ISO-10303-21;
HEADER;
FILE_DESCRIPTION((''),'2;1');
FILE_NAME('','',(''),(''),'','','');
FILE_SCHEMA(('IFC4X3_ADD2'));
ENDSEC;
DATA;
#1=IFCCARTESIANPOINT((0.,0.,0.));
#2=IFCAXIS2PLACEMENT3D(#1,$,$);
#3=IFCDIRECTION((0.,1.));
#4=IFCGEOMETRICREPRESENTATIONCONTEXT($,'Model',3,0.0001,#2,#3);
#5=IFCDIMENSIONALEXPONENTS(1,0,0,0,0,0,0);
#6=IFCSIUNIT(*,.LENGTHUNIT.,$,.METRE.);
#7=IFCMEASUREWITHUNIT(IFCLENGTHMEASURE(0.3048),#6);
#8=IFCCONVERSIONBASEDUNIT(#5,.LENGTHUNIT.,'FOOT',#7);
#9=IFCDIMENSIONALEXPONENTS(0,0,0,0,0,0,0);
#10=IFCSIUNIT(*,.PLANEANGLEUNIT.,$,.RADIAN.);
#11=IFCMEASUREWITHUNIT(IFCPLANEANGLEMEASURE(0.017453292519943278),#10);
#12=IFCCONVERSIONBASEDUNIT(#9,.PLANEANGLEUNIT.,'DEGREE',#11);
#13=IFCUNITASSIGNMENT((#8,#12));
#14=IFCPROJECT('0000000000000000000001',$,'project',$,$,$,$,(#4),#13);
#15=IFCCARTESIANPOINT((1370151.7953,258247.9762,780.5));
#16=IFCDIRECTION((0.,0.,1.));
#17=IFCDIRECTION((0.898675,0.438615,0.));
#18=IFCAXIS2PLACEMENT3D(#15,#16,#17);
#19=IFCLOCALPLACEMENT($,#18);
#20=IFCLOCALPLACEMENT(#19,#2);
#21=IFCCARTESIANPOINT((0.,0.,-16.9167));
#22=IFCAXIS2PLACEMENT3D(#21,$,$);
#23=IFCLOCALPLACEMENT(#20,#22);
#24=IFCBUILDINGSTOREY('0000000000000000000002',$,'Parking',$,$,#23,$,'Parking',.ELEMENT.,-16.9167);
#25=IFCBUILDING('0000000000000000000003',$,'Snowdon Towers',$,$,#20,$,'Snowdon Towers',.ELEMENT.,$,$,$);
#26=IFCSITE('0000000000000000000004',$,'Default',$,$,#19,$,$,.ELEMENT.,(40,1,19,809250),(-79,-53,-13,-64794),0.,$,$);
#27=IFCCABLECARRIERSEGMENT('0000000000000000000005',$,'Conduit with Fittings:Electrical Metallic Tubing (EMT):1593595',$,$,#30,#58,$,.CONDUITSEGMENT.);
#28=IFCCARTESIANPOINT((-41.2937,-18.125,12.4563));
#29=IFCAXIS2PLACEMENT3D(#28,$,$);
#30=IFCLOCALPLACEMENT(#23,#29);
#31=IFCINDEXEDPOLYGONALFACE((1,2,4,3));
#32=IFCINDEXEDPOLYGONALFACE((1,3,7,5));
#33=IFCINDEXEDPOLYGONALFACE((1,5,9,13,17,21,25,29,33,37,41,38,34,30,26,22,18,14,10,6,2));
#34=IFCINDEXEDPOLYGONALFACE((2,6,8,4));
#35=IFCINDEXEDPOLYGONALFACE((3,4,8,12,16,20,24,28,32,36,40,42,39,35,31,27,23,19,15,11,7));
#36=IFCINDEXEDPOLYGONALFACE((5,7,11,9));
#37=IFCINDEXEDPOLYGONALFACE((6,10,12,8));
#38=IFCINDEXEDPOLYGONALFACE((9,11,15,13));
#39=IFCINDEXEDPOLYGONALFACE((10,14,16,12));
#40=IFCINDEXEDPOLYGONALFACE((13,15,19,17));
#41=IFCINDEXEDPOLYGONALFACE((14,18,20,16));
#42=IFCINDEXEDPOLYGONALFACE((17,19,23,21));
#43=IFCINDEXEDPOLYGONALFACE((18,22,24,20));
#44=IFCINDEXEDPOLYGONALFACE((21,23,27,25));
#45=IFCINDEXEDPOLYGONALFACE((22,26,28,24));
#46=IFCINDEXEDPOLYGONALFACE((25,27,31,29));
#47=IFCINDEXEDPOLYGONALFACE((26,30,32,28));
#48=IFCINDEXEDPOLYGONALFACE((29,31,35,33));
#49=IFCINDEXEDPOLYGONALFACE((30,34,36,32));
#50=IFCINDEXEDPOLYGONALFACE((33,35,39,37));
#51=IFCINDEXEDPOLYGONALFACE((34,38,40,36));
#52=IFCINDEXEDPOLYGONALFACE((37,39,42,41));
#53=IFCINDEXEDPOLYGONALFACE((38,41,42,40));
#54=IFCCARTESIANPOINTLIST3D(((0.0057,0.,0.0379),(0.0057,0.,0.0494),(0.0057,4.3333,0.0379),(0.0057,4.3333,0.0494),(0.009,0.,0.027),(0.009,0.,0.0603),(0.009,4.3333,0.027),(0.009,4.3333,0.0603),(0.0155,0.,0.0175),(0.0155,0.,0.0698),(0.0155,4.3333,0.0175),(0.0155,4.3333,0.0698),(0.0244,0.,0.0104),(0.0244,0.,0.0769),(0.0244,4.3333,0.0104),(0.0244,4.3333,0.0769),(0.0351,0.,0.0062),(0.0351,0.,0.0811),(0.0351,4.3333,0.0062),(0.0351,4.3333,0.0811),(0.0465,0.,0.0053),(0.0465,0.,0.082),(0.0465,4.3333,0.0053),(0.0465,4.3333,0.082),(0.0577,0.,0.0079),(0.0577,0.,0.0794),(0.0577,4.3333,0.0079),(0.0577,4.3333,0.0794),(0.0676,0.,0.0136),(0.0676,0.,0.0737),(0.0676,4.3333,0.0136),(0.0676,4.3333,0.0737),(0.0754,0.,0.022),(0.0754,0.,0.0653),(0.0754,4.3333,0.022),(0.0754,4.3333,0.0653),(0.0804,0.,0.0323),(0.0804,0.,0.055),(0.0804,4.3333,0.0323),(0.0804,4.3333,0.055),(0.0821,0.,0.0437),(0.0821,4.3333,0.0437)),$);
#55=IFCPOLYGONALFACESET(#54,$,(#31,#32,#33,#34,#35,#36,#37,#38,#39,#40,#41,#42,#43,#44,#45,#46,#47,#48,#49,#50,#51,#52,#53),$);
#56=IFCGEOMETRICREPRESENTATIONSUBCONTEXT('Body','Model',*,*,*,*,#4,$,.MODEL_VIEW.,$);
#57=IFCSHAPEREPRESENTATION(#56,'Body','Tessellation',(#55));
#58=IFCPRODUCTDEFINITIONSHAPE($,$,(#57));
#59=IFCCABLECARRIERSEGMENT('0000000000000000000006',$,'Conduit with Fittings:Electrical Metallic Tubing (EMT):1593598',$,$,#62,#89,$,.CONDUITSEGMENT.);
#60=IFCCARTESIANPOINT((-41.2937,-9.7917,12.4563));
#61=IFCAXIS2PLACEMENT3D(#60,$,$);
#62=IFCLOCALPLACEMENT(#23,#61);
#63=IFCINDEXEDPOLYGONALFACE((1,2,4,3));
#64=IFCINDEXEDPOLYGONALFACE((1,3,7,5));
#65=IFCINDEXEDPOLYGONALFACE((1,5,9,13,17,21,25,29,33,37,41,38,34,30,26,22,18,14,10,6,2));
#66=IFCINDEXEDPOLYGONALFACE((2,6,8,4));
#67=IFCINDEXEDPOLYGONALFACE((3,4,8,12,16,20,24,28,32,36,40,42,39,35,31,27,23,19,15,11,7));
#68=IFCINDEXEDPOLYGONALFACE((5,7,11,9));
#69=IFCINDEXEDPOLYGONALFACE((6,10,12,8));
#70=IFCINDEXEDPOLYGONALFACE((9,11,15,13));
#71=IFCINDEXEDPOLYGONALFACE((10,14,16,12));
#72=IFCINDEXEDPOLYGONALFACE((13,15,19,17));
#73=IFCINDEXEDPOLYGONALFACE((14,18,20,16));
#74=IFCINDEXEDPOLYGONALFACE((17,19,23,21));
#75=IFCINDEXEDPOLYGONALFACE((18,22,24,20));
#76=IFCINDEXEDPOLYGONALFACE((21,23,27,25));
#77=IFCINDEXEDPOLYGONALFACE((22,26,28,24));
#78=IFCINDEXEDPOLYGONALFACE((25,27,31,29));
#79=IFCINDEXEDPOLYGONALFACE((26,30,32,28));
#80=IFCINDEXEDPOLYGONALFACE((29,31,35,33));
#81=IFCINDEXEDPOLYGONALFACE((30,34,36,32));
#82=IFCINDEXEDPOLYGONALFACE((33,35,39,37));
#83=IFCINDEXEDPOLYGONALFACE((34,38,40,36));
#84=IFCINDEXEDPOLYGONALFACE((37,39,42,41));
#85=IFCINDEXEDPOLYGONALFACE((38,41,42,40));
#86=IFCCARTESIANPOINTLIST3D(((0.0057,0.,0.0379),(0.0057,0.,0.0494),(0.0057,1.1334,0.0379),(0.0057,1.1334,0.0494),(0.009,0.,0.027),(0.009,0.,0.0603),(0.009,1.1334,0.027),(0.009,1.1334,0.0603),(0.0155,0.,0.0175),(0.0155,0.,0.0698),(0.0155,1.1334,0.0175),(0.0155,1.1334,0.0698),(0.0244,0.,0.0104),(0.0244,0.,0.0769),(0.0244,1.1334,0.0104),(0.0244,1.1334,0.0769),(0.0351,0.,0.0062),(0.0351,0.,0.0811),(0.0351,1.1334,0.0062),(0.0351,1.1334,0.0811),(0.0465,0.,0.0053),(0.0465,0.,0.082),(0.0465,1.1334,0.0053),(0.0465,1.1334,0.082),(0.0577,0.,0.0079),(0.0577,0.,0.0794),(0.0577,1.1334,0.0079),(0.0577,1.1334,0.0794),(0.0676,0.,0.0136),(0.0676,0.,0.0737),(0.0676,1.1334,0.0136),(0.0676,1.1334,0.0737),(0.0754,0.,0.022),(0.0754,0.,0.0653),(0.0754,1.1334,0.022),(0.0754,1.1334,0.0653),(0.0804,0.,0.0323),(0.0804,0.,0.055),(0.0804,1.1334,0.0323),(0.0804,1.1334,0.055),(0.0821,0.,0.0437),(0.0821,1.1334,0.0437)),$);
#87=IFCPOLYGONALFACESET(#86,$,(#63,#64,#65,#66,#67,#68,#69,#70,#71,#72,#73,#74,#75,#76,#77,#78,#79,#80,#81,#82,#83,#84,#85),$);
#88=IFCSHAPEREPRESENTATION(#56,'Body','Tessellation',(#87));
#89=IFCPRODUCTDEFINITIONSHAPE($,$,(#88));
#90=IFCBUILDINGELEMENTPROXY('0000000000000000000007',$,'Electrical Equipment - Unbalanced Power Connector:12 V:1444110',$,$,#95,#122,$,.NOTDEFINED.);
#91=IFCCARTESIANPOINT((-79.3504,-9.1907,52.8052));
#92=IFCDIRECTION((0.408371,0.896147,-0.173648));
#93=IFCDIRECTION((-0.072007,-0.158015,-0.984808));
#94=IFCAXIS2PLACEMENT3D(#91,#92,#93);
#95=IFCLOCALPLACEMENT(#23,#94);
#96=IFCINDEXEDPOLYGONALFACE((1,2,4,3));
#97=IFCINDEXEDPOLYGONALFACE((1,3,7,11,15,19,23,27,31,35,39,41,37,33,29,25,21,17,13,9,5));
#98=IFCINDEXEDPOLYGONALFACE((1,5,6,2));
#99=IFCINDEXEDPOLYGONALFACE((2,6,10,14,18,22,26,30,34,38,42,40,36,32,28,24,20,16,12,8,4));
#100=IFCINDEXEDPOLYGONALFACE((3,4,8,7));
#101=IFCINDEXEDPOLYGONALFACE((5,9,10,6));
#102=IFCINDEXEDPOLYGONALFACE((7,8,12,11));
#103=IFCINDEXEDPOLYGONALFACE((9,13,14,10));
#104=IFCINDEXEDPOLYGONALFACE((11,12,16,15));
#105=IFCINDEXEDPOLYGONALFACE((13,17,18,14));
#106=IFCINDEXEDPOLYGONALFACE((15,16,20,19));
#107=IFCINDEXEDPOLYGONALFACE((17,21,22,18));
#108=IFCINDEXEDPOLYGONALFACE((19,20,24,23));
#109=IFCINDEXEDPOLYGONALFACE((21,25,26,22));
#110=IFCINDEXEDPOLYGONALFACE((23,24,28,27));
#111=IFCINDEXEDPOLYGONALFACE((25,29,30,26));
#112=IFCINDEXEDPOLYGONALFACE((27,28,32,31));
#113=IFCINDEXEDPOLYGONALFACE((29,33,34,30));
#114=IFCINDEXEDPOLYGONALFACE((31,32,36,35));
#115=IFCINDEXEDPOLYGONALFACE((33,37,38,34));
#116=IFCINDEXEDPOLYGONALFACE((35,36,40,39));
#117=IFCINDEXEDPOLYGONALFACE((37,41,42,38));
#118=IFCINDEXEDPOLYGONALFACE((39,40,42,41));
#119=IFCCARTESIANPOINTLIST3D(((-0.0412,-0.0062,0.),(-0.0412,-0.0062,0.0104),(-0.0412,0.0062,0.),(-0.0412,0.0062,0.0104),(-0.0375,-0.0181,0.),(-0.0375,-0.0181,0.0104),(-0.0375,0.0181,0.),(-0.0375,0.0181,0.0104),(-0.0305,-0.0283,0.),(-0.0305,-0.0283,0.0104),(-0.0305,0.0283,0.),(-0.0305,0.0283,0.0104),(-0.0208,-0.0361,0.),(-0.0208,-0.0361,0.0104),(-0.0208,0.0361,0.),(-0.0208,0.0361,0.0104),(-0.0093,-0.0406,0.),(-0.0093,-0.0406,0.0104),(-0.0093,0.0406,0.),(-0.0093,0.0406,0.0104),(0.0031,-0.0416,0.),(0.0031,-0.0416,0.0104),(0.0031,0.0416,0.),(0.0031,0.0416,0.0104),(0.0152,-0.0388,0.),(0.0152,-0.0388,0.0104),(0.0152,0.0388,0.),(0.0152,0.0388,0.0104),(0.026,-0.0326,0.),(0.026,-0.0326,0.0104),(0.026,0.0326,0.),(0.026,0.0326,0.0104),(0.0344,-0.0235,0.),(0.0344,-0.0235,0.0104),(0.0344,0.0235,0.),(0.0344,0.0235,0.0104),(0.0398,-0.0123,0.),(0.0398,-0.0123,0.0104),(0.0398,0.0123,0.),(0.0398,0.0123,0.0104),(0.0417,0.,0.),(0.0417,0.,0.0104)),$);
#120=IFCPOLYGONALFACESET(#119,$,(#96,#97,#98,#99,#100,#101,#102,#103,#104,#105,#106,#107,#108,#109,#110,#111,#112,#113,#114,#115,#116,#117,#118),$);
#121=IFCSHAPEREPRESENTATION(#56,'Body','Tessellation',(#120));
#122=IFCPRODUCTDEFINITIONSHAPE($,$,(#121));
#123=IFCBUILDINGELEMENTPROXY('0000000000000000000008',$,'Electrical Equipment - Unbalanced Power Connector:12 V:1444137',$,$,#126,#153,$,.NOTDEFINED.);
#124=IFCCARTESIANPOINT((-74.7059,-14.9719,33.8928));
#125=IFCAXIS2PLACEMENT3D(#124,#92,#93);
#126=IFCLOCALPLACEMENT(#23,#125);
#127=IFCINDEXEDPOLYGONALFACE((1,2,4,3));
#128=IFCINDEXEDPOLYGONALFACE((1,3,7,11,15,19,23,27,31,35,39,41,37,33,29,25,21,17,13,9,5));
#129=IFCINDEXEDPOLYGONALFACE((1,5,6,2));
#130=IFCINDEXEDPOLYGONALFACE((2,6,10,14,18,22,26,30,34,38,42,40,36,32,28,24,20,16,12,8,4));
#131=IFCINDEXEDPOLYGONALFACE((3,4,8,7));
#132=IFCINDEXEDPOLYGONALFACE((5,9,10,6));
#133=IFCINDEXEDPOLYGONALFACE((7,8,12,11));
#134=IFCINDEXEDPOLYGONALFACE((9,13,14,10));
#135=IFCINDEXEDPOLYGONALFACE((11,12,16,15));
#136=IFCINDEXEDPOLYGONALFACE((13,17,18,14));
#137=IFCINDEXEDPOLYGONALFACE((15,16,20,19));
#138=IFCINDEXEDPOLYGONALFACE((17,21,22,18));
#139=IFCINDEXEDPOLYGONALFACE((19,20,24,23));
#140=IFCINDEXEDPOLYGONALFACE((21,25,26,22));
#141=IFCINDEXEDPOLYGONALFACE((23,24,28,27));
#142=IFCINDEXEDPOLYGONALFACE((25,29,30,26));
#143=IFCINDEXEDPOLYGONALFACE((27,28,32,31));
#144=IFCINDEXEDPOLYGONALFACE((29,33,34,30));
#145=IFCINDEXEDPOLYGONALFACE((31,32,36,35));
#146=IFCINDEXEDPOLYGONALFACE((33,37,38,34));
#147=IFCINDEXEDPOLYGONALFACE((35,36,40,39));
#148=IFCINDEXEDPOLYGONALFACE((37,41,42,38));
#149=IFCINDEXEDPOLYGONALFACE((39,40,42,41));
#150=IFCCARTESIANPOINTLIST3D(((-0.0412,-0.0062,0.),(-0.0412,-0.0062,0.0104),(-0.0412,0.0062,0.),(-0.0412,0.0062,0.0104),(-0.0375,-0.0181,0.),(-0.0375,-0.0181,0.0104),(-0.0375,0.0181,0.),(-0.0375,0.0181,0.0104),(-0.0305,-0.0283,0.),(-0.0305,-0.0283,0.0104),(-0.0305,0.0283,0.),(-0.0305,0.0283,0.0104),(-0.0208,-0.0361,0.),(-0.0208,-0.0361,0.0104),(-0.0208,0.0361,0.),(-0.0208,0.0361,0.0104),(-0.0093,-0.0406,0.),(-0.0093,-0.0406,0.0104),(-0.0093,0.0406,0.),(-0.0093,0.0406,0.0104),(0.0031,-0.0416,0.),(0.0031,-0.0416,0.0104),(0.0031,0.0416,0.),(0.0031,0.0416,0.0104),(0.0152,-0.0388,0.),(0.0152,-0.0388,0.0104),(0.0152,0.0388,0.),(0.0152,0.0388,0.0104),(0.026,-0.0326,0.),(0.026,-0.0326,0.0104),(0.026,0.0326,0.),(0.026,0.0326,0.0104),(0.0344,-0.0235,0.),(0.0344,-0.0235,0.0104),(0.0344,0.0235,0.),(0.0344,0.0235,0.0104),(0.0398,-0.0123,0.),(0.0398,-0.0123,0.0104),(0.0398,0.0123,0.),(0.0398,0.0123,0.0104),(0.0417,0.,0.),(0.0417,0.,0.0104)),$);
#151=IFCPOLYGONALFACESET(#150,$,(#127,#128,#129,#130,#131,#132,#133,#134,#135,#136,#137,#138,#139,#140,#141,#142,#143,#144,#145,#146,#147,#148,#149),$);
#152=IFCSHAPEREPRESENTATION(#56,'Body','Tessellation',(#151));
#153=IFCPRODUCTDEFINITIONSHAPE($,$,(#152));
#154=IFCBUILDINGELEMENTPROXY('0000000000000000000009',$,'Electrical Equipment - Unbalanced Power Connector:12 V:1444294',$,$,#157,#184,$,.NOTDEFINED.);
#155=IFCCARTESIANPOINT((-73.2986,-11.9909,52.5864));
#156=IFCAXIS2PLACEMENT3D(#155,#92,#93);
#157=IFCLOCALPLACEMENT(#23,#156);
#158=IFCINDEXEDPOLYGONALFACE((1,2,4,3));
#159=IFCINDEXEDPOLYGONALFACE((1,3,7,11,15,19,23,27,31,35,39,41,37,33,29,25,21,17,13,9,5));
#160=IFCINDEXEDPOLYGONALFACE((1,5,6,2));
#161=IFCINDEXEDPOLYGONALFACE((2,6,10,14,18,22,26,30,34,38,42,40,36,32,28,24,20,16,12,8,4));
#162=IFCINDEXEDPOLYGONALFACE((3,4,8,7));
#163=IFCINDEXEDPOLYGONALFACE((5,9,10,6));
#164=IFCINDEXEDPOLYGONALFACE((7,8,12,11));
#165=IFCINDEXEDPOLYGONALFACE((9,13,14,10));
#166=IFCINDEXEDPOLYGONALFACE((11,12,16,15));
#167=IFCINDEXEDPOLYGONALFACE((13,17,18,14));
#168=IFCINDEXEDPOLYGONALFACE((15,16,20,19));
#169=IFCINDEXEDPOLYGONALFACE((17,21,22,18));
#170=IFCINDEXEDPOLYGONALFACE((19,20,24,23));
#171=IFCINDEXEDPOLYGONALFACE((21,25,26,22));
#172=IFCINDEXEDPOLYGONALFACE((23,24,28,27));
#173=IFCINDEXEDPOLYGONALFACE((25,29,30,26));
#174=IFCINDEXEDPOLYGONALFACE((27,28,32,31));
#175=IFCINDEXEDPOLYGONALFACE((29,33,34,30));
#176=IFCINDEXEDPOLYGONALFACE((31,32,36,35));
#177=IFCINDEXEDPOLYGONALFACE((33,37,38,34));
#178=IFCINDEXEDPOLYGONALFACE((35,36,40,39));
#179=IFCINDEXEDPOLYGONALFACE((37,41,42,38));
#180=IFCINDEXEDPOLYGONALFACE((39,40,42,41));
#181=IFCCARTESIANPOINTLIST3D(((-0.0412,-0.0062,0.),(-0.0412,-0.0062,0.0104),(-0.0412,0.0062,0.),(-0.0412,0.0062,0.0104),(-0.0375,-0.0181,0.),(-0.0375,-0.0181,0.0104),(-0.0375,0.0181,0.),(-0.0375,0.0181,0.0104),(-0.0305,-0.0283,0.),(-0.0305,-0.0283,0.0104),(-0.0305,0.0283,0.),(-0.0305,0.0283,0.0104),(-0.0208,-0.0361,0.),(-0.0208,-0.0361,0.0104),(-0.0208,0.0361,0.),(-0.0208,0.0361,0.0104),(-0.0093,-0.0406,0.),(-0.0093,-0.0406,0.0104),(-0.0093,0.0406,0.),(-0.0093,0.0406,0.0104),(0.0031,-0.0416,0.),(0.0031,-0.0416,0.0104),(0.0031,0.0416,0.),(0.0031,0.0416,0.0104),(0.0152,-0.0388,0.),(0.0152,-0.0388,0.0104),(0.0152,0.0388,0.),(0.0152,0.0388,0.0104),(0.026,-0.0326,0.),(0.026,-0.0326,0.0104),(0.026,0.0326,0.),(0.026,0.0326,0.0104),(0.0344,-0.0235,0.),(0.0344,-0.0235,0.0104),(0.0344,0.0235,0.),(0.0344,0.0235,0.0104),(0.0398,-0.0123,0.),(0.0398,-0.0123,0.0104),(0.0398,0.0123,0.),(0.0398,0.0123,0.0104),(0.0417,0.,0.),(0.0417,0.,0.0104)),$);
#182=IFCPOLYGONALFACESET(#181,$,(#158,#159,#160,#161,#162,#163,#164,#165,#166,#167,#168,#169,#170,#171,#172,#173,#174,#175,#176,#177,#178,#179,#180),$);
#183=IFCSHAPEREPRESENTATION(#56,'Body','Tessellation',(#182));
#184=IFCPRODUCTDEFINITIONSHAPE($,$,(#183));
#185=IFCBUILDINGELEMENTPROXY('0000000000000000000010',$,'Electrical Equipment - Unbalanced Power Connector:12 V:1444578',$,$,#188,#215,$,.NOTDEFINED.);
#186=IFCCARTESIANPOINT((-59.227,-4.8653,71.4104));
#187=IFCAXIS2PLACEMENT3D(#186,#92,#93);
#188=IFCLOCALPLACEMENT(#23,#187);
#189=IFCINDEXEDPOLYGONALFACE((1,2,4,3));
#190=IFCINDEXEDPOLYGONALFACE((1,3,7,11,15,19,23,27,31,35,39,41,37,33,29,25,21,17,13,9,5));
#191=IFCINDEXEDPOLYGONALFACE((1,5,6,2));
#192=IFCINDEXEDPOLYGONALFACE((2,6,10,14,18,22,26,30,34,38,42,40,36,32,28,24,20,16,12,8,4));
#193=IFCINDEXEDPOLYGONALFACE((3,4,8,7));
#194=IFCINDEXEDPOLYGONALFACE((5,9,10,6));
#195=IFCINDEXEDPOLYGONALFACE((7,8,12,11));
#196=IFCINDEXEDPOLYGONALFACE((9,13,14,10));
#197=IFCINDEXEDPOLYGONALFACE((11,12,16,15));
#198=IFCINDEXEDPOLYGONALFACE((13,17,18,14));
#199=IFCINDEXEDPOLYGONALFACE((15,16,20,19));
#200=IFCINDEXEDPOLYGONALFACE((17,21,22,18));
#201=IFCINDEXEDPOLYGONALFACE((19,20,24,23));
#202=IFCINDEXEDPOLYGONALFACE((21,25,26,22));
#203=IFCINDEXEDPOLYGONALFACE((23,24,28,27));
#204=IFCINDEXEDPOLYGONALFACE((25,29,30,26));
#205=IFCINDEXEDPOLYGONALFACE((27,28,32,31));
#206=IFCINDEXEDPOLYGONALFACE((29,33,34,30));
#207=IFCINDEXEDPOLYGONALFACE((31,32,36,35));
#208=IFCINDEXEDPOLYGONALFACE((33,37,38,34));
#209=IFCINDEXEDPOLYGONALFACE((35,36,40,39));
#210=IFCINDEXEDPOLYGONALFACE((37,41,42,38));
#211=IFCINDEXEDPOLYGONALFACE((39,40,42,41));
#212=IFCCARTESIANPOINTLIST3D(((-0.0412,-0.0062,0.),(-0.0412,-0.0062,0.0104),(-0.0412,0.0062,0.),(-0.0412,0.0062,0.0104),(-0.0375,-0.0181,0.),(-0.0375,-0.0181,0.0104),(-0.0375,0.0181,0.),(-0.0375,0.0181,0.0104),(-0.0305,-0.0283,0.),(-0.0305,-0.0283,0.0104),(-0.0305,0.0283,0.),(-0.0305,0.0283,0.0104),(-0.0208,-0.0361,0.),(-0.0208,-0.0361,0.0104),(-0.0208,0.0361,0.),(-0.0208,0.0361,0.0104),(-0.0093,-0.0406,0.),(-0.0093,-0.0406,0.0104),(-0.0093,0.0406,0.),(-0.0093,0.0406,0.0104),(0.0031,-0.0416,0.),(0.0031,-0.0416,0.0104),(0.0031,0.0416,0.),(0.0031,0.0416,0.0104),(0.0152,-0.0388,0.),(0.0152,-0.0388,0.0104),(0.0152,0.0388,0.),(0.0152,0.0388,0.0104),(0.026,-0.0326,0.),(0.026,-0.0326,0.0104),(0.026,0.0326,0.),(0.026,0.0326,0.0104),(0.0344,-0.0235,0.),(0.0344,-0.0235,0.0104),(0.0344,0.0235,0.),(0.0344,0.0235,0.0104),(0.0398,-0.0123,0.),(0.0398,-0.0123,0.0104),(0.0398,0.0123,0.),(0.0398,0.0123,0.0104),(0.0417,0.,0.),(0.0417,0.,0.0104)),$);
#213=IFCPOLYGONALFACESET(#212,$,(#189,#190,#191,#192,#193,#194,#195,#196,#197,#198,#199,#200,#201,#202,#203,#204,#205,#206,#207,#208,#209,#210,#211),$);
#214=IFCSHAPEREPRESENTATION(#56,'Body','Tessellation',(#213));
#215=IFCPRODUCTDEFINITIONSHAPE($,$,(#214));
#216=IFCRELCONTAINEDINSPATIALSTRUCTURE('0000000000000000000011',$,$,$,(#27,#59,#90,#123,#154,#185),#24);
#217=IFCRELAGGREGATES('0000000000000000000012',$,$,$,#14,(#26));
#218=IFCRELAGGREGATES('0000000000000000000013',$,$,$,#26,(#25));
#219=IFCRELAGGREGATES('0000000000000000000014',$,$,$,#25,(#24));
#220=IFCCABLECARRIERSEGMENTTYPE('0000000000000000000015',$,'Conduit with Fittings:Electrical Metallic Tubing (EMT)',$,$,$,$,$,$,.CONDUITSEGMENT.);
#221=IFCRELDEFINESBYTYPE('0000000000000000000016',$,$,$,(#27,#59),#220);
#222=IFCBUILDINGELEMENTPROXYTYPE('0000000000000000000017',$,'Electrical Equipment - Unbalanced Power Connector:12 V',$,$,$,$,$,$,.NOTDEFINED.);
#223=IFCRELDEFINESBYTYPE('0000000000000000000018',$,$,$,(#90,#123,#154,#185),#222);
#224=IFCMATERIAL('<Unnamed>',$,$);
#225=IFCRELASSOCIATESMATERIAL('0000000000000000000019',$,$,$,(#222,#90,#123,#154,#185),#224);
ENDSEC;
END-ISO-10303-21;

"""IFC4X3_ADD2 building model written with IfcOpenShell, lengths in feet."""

from ifc_helpers import new_model, entity, si_unit, converted_unit, direction, frame, frame_2d, origin, origin_2d_with_axis, place, context, subcontext, project, spatial, circle, extrude, source, transform, mapped, material, type_object, type_shapes, element, save


model = new_model("IFC4X3_ADD2")

# Units and contexts
model_context = context("Model", 3, precision=0.0001, world=origin(), true_north=direction((0.0, 1.0)))
body_context = subcontext(model_context, "Body", "Model", "MODEL_VIEW")
ifc_project = project(units=[converted_unit("LENGTHUNIT", "FOOT", entity("IfcLengthMeasure", 0.3048), si_unit("LENGTHUNIT", "METRE"), dimensions=[1, 0, 0, 0, 0, 0, 0]), converted_unit("PLANEANGLEUNIT", "DEGREE", entity("IfcPlaneAngleMeasure", 0.017453292519943278), si_unit("PLANEANGLEUNIT", "RADIAN"), dimensions=[0, 0, 0, 0, 0, 0, 0])], contexts=[model_context])

# Site, building, storey
site_placement = place(None, frame((1370151.7953, 258247.9762, 780.5), z_axis=(0.0, 0.0, 1.0), x_axis=(0.898675, 0.438615, 0.0)))
site = spatial("IfcSite", under=ifc_project, at=site_placement, Name="Default", CompositionType="ELEMENT", RefLatitude=(40, 1, 19, 809250), RefLongitude=(-79, -53, -13, -64794), RefElevation=0.0)
building_placement = place(site_placement, origin())
building = spatial("IfcBuilding", under=site, at=building_placement, Name="Snowdon Towers", LongName="Snowdon Towers", CompositionType="ELEMENT")
storey_placement = place(building_placement, frame((0.0, 0.0, -16.9167)))
storey = spatial("IfcBuildingStorey", under=building, at=storey_placement, Name="Parking", LongName="Parking", CompositionType="ELEMENT", Elevation=-16.9167)

# Cable carrier segments
cable_carrier_segment_type = type_object("IfcCableCarrierSegmentType", Name="Conduit with Fittings:Electrical Metallic Tubing (EMT)", PredefinedType="CONDUITSEGMENT")
cable_carrier_segment_1_placement = place(storey_placement, frame((-41.2937, -18.125, 12.4563)))
element("IfcCableCarrierSegment", 1, at=cable_carrier_segment_1_placement, inside=storey, type_object=cable_carrier_segment_type, Name="Conduit with Fittings:Electrical Metallic Tubing (EMT):1593595", PredefinedType="CONDUITSEGMENT", context=body_context, shape_type="SweptSolid", body=[
    extrude(circle(Radius=0.0384, at=origin_2d_with_axis()), frame((0.0437, 0.0, 0.0437), z_axis=(0.0, 1.0, 0.0), x_axis=(1.0, 0.0, 0.0)), (0.0, 0.0, 1.0), 4.3333),
])
cable_carrier_segment_2_placement = place(storey_placement, frame((-41.2937, -9.7917, 12.4563)))
element("IfcCableCarrierSegment", 2, at=cable_carrier_segment_2_placement, inside=storey, type_object=cable_carrier_segment_type, Name="Conduit with Fittings:Electrical Metallic Tubing (EMT):1593598", PredefinedType="CONDUITSEGMENT", context=body_context, shape_type="SweptSolid", body=[
    extrude(circle(Radius=0.0384, at=origin_2d_with_axis()), frame((0.0437, 0.0, 0.0437), z_axis=(0.0, 1.0, 0.0), x_axis=(1.0, 0.0, 0.0)), (0.0, 0.0, 1.0), 1.1334),
])

# Building element proxies
ifc_material_1 = material(Name="<Unnamed>")
building_element_proxy_type = type_object("IfcBuildingElementProxyType", Name="Electrical Equipment - Unbalanced Power Connector:12 V", PredefinedType="NOTDEFINED", material=ifc_material_1)
shared_shape_1 = source(origin(), body_context, "Body", "SweptSolid", [
    extrude(circle(Radius=0.0417, at=frame_2d((0.0, 0.0), x_axis=(1.0, 0.0))), origin(), (0.0, 0.0, 1.0), 0.0104),
])
type_shapes(building_element_proxy_type, [shared_shape_1])
for number, where, z_axis, x_axis, name in (
    (3, (-79.3504, -9.1907, 52.8052), (0.408371, 0.896147, -0.173648), (-0.072007, -0.158015, -0.984808), "Electrical Equipment - Unbalanced Power Connector:12 V:1444110"),
    (4, (-74.7059, -14.9719, 33.8928), (0.408371, 0.896147, -0.173648), (-0.072007, -0.158015, -0.984808), "Electrical Equipment - Unbalanced Power Connector:12 V:1444137"),
    (5, (-73.2986, -11.9909, 52.5864), (0.408371, 0.896147, -0.173648), (-0.072007, -0.158015, -0.984808), "Electrical Equipment - Unbalanced Power Connector:12 V:1444294"),
    (6, (-59.227, -4.8653, 71.4104), (0.408371, 0.896147, -0.173648), (-0.072007, -0.158015, -0.984808), "Electrical Equipment - Unbalanced Power Connector:12 V:1444578"),
):
    element("IfcBuildingElementProxy", number, at=place(storey_placement, frame(where, z_axis=z_axis, x_axis=x_axis)), inside=storey, type_object=building_element_proxy_type, material=ifc_material_1, Name=name, PredefinedType="NOTDEFINED", context=body_context, shape_type="MappedRepresentation", body=[
        mapped(shared_shape_1, transform((0.0, 0.0, 0.0), scale=1.0)),
    ])

save(model, "model.ifc")
